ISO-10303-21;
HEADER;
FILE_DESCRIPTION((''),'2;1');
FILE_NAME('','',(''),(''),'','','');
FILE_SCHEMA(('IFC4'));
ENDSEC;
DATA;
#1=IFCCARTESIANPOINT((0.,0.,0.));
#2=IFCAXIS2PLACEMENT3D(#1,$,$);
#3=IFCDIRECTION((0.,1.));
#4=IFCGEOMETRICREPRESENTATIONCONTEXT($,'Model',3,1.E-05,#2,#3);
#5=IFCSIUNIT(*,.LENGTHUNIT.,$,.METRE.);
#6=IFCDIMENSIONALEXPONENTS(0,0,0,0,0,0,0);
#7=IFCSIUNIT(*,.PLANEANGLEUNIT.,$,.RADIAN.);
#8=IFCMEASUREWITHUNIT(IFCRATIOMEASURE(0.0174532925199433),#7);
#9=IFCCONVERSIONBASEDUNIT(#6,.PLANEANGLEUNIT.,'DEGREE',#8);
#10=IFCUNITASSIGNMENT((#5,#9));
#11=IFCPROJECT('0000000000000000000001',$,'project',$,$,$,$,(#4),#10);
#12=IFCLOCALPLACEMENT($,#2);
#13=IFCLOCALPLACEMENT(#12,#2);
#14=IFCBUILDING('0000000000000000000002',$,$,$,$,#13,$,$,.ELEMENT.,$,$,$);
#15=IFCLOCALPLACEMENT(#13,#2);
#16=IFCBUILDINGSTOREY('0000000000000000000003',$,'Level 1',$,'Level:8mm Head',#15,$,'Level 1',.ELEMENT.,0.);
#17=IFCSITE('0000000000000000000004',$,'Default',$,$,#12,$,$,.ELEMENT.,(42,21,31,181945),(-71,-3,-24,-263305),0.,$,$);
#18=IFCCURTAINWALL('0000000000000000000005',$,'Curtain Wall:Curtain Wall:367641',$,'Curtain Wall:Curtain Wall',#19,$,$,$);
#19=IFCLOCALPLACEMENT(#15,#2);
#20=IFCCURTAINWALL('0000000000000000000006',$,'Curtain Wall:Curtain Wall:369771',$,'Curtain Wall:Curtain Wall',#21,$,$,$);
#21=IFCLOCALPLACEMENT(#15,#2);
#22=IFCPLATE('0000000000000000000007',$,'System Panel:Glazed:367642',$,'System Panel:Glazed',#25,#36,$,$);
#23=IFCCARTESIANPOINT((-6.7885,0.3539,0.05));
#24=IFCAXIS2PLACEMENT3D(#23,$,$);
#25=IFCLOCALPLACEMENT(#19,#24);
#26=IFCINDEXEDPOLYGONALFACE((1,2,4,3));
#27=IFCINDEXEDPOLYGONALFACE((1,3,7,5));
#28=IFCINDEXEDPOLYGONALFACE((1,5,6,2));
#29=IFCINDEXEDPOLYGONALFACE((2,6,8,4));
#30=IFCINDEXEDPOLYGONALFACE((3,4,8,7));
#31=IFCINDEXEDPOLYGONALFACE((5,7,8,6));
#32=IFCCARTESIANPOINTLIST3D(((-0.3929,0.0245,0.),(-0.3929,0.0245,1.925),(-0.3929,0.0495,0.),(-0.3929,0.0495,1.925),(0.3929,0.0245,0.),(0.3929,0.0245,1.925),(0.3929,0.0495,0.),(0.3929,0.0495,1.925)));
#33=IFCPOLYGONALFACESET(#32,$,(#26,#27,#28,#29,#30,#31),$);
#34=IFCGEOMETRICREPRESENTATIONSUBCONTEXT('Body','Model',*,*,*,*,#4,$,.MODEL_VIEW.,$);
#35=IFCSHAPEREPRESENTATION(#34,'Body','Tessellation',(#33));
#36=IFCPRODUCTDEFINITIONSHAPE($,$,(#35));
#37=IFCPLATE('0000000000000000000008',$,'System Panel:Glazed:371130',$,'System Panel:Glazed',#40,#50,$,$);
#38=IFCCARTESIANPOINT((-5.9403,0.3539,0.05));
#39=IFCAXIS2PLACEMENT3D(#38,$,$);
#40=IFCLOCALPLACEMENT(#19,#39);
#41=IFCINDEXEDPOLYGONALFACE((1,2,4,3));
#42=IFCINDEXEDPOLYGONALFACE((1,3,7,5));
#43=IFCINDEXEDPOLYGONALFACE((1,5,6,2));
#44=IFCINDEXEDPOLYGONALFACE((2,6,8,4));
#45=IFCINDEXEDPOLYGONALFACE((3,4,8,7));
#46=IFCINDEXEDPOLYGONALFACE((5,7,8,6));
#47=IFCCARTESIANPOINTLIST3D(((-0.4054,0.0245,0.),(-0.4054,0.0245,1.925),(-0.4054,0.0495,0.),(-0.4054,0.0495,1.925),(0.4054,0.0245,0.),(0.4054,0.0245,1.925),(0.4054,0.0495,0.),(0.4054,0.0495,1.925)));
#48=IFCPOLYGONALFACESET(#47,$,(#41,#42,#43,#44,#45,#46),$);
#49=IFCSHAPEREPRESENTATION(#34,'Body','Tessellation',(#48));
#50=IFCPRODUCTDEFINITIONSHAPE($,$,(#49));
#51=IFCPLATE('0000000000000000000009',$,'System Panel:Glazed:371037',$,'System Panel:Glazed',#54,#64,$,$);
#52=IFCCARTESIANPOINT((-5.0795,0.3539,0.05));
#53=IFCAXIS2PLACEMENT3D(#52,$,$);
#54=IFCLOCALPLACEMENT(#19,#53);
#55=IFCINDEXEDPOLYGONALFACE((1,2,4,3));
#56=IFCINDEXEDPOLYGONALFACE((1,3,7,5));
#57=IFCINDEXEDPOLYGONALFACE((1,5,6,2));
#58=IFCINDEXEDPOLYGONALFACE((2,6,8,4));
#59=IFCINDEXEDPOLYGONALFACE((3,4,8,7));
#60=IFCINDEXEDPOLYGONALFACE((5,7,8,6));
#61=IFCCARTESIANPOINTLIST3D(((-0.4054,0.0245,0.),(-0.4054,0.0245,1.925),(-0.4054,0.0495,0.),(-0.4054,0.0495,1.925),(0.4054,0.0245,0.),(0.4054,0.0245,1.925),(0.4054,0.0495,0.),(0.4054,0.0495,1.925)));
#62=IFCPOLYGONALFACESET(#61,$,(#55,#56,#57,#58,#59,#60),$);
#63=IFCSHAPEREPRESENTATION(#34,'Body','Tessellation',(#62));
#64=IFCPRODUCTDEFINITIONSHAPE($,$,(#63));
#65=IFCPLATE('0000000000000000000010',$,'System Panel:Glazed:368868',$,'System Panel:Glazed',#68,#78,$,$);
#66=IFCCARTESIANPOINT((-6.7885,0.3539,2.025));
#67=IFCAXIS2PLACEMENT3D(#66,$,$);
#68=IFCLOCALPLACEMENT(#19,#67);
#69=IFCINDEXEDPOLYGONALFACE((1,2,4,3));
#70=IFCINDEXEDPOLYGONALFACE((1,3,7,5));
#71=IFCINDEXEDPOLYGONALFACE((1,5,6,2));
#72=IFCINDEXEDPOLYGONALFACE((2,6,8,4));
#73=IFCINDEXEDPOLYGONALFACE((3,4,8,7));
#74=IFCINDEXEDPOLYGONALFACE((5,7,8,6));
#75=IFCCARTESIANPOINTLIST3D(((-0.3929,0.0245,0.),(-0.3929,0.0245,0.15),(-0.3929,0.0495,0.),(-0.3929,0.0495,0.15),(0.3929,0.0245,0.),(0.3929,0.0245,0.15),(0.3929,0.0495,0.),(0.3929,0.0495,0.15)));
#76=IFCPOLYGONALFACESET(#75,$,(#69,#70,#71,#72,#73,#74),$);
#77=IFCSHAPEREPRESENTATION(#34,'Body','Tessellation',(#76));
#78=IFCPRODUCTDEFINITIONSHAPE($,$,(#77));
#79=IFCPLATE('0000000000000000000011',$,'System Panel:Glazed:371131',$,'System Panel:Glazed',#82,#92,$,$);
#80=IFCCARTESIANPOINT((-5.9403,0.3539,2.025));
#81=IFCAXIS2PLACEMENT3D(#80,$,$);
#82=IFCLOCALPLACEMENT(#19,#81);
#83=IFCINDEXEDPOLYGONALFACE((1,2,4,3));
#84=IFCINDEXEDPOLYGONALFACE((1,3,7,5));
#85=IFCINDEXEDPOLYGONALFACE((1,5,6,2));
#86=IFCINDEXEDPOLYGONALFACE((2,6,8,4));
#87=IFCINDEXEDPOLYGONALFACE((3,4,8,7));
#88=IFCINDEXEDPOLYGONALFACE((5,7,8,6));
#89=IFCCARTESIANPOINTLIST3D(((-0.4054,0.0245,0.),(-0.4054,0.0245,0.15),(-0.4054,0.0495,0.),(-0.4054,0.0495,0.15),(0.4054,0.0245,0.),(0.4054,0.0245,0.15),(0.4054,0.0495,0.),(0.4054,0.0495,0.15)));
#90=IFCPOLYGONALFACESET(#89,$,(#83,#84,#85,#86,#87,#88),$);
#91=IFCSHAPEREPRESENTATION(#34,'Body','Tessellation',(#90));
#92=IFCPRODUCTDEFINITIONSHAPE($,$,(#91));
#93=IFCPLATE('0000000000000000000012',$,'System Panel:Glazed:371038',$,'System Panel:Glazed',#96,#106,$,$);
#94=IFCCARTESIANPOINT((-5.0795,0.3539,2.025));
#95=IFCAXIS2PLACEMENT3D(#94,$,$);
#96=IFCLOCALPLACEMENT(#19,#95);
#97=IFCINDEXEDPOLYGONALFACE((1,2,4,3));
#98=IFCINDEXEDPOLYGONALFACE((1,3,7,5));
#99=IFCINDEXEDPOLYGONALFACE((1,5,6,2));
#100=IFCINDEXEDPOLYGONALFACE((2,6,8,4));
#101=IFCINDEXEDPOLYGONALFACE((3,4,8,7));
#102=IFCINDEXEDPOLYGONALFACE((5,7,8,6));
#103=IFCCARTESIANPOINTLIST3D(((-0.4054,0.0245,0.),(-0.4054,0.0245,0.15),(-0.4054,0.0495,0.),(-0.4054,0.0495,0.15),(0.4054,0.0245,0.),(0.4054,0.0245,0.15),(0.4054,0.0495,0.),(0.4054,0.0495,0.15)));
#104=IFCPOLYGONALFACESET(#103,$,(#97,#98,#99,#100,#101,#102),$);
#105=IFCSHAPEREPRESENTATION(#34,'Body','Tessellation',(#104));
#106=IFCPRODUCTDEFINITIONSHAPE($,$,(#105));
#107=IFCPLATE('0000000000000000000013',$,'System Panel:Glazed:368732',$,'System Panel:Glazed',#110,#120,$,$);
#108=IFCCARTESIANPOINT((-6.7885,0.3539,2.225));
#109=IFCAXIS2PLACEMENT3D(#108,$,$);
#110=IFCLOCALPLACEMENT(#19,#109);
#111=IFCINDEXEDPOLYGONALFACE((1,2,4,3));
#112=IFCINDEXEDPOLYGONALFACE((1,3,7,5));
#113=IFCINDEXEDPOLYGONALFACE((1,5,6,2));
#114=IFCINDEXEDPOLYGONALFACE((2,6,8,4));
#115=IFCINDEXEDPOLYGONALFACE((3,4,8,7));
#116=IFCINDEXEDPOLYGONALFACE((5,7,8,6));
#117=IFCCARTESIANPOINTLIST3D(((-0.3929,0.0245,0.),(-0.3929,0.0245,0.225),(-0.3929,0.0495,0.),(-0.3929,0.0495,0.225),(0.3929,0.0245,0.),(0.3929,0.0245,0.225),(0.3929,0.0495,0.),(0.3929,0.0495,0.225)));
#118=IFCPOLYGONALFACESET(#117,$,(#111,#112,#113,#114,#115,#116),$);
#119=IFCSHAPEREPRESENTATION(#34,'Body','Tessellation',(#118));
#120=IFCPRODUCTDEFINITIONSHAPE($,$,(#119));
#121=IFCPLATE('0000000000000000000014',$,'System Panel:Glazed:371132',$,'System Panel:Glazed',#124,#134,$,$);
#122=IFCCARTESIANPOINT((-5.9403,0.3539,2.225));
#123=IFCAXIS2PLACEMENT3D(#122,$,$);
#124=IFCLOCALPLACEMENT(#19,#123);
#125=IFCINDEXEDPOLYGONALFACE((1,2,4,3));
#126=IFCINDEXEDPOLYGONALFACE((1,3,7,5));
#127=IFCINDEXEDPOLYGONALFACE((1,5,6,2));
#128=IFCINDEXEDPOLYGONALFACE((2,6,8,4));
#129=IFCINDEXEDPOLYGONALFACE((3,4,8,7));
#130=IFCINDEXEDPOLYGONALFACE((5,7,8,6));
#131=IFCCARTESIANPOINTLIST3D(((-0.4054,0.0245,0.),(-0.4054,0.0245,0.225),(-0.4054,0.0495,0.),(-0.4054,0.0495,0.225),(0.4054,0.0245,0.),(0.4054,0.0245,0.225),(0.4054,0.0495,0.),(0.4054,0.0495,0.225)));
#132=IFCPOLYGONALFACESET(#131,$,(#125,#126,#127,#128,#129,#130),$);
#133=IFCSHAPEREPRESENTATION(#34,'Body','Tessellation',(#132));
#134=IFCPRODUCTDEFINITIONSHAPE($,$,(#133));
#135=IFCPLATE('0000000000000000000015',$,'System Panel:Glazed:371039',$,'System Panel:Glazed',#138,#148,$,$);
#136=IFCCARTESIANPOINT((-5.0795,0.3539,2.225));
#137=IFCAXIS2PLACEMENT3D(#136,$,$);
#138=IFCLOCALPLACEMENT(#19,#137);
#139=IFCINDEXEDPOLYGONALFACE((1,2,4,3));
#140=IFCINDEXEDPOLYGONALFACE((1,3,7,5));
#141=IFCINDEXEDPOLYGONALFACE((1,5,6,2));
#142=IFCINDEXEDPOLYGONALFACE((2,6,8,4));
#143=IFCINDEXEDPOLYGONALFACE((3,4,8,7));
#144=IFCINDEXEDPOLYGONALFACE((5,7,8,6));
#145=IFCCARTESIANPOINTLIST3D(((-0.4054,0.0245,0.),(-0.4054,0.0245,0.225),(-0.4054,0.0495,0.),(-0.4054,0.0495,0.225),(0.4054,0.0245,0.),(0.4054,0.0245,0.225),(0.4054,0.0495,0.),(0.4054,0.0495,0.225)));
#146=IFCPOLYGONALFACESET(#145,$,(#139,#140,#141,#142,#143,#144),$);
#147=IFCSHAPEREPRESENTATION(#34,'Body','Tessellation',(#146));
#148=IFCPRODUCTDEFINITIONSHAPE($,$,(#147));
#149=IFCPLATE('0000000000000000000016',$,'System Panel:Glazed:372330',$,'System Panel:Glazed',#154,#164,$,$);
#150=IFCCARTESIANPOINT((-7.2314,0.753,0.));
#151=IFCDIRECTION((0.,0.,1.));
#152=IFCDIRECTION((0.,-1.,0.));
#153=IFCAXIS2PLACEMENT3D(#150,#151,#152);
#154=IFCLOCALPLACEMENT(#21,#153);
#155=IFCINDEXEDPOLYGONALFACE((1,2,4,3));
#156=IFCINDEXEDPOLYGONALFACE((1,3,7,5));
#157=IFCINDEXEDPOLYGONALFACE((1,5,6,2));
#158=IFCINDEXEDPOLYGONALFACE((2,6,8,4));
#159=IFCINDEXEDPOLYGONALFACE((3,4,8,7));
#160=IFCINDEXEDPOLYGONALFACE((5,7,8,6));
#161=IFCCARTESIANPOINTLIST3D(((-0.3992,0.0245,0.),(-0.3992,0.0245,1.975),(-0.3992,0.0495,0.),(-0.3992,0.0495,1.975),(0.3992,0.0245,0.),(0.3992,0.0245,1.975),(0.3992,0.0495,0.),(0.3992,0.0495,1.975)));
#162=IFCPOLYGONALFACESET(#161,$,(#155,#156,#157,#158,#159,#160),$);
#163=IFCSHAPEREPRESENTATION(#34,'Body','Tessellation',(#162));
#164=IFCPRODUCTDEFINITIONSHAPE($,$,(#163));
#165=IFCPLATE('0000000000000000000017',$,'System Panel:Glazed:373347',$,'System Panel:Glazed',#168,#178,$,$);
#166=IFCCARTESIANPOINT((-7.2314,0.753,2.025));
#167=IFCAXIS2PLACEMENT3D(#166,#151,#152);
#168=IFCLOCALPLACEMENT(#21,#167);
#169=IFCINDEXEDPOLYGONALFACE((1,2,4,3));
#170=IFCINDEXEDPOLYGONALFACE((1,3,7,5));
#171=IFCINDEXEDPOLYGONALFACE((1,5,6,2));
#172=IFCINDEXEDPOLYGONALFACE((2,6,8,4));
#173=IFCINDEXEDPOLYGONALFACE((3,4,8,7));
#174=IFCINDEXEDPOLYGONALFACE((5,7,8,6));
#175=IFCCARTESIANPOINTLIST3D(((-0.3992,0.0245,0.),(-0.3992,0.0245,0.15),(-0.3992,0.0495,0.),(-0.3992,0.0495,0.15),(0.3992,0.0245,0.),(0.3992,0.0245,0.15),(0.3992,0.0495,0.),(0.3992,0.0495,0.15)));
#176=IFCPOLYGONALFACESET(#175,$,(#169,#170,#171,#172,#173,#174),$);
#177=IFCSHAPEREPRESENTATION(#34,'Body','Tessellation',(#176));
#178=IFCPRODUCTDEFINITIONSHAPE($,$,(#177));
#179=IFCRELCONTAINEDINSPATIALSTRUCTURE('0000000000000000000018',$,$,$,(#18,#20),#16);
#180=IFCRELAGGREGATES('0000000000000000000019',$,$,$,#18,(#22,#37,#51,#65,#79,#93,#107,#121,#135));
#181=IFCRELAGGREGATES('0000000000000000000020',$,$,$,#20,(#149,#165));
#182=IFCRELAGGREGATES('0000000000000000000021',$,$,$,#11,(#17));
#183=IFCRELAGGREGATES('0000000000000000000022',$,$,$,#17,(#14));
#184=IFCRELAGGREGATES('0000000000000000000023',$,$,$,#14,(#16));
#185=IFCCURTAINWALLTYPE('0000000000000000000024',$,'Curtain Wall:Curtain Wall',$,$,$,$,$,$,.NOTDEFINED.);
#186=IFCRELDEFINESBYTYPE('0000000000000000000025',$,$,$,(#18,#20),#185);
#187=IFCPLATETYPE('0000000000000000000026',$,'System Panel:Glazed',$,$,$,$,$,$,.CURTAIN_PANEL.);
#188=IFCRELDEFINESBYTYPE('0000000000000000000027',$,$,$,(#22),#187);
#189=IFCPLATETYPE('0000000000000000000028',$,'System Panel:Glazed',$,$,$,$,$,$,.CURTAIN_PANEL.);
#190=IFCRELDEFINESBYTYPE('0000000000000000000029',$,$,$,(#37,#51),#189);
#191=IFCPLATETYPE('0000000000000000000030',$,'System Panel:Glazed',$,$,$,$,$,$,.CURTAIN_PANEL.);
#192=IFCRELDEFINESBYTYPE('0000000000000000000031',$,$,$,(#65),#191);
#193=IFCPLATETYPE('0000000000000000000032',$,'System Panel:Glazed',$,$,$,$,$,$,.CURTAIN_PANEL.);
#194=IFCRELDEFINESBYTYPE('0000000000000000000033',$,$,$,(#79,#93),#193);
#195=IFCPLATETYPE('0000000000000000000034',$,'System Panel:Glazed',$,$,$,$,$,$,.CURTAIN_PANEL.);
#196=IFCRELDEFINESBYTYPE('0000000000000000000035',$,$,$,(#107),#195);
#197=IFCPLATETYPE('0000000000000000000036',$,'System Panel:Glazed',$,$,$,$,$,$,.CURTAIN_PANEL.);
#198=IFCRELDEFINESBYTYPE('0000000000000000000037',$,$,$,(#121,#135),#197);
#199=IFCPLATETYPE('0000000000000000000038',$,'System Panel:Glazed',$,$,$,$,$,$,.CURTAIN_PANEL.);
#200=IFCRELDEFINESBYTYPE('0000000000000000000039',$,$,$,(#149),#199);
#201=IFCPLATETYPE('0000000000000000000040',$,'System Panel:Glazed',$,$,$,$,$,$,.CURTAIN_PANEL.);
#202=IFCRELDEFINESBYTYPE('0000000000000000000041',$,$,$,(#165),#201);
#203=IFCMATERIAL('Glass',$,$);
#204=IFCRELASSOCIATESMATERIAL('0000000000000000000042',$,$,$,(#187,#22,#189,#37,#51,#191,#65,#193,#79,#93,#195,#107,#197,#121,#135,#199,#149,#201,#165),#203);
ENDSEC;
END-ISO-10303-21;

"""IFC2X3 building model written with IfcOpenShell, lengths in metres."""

from ifc_helpers import new_model, entity, si_unit, converted_unit, direction, frame, origin, origin_2d_with_axis, place, context, subcontext, project, spatial, rectangle, extrude, source, transform, mapped, material, type_object, type_shapes, element, aggregate, save


model = new_model("IFC2X3")

# Units and contexts
model_context = context("Model", 3, precision=1e-05, world=origin(), true_north=direction((0.0, 1.0)))
body_context = subcontext(model_context, "Body", "Model", "MODEL_VIEW")
ifc_project = project(units=[si_unit("LENGTHUNIT", "METRE"), converted_unit("PLANEANGLEUNIT", "DEGREE", entity("IfcRatioMeasure", 0.0174532925199433), si_unit("PLANEANGLEUNIT", "RADIAN"), dimensions=[0, 0, 0, 0, 0, 0, 0])], contexts=[model_context])

# Site, building, storey
site_placement = place(None, origin())
site = spatial("IfcSite", under=ifc_project, at=site_placement, Name="Default", CompositionType="ELEMENT", RefLatitude=(42, 21, 31, 181945), RefLongitude=(-71, -3, -24, -263305), RefElevation=0.0)
building_placement = place(site_placement, origin())
building = spatial("IfcBuilding", under=site, at=building_placement, CompositionType="ELEMENT")
storey_placement = place(building_placement, origin())
storey = spatial("IfcBuildingStorey", under=building, at=storey_placement, Name="Level 1", ObjectType="Level:8mm Head", LongName="Level 1", CompositionType="ELEMENT", Elevation=0.0)

# Curtain walls
curtain_wall_type = type_object("IfcCurtainWallType", Name="Curtain Wall:Curtain Wall", PredefinedType="NOTDEFINED")
curtain_wall_1_placement = place(storey_placement, origin())
curtain_wall_1 = element("IfcCurtainWall", 1, at=curtain_wall_1_placement, inside=storey, type_object=curtain_wall_type, Name="Curtain Wall:Curtain Wall:367641", ObjectType="Curtain Wall:Curtain Wall")
curtain_wall_2_placement = place(storey_placement, origin())
curtain_wall_2 = element("IfcCurtainWall", 2, at=curtain_wall_2_placement, inside=storey, type_object=curtain_wall_type, Name="Curtain Wall:Curtain Wall:369771", ObjectType="Curtain Wall:Curtain Wall")

# Plates
ifc_material_1 = material(Name="Glass")
plate_type_1 = type_object("IfcPlateType", Name="System Panel:Glazed", PredefinedType="CURTAIN_PANEL", material=ifc_material_1)
shared_shape_1 = source(origin(), body_context, "Body", "SweptSolid", [
    extrude(rectangle(XDim=0.025, YDim=0.7857, at=origin_2d_with_axis()), frame((0.0, 0.037, 0.0), z_axis=(0.0, 0.0, 1.0), x_axis=(0.0, 1.0, 0.0)), (0.0, 0.0, 1.0), 1.925),
])
type_shapes(plate_type_1, [shared_shape_1])
plate_1_placement = place(curtain_wall_1_placement, frame((-6.7885, 0.3539, 0.05)))
plate_1 = element("IfcPlate", 3, at=plate_1_placement, type_object=plate_type_1, material=ifc_material_1, Name="System Panel:Glazed:367642", ObjectType="System Panel:Glazed", context=body_context, shape_type="MappedRepresentation", body=[
    mapped(shared_shape_1, transform((0.0, 0.0, 0.0), scale=1.0)),
])
plate_type_2 = type_object("IfcPlateType", Name="System Panel:Glazed", PredefinedType="CURTAIN_PANEL", material=ifc_material_1)
shared_shape_2 = source(origin(), body_context, "Body", "SweptSolid", [
    extrude(rectangle(XDim=0.025, YDim=0.8107, at=origin_2d_with_axis()), frame((0.0, 0.037, 0.0), z_axis=(0.0, 0.0, 1.0), x_axis=(0.0, 1.0, 0.0)), (0.0, 0.0, 1.0), 1.925),
])
type_shapes(plate_type_2, [shared_shape_2])
plate_2_placement = place(curtain_wall_1_placement, frame((-5.9403, 0.3539, 0.05)))
plate_2 = element("IfcPlate", 4, at=plate_2_placement, type_object=plate_type_2, material=ifc_material_1, Name="System Panel:Glazed:371130", ObjectType="System Panel:Glazed", context=body_context, shape_type="MappedRepresentation", body=[
    mapped(shared_shape_2, transform((0.0, 0.0, 0.0), scale=1.0)),
])
plate_3_placement = place(curtain_wall_1_placement, frame((-5.0795, 0.3539, 0.05)))
plate_3 = element("IfcPlate", 5, at=plate_3_placement, type_object=plate_type_2, material=ifc_material_1, Name="System Panel:Glazed:371037", ObjectType="System Panel:Glazed", context=body_context, shape_type="MappedRepresentation", body=[
    mapped(shared_shape_2, transform((0.0, 0.0, 0.0), scale=1.0)),
])
plate_type_3 = type_object("IfcPlateType", Name="System Panel:Glazed", PredefinedType="CURTAIN_PANEL", material=ifc_material_1)
shared_shape_3 = source(origin(), body_context, "Body", "SweptSolid", [
    extrude(rectangle(XDim=0.025, YDim=0.7857, at=origin_2d_with_axis()), frame((0.0, 0.037, 0.0), z_axis=(0.0, 0.0, 1.0), x_axis=(0.0, 1.0, 0.0)), (0.0, 0.0, 1.0), 0.15),
])
type_shapes(plate_type_3, [shared_shape_3])
plate_4_placement = place(curtain_wall_1_placement, frame((-6.7885, 0.3539, 2.025)))
plate_4 = element("IfcPlate", 6, at=plate_4_placement, type_object=plate_type_3, material=ifc_material_1, Name="System Panel:Glazed:368868", ObjectType="System Panel:Glazed", context=body_context, shape_type="MappedRepresentation", body=[
    mapped(shared_shape_3, transform((0.0, 0.0, 0.0), scale=1.0)),
])
plate_type_4 = type_object("IfcPlateType", Name="System Panel:Glazed", PredefinedType="CURTAIN_PANEL", material=ifc_material_1)
shared_shape_4 = source(origin(), body_context, "Body", "SweptSolid", [
    extrude(rectangle(XDim=0.025, YDim=0.8107, at=origin_2d_with_axis()), frame((0.0, 0.037, 0.0), z_axis=(0.0, 0.0, 1.0), x_axis=(0.0, 1.0, 0.0)), (0.0, 0.0, 1.0), 0.15),
])
type_shapes(plate_type_4, [shared_shape_4])
plate_5_placement = place(curtain_wall_1_placement, frame((-5.9403, 0.3539, 2.025)))
plate_5 = element("IfcPlate", 7, at=plate_5_placement, type_object=plate_type_4, material=ifc_material_1, Name="System Panel:Glazed:371131", ObjectType="System Panel:Glazed", context=body_context, shape_type="MappedRepresentation", body=[
    mapped(shared_shape_4, transform((0.0, 0.0, 0.0), scale=1.0)),
])
plate_6_placement = place(curtain_wall_1_placement, frame((-5.0795, 0.3539, 2.025)))
plate_6 = element("IfcPlate", 8, at=plate_6_placement, type_object=plate_type_4, material=ifc_material_1, Name="System Panel:Glazed:371038", ObjectType="System Panel:Glazed", context=body_context, shape_type="MappedRepresentation", body=[
    mapped(shared_shape_4, transform((0.0, 0.0, 0.0), scale=1.0)),
])
plate_type_5 = type_object("IfcPlateType", Name="System Panel:Glazed", PredefinedType="CURTAIN_PANEL", material=ifc_material_1)
shared_shape_5 = source(origin(), body_context, "Body", "SweptSolid", [
    extrude(rectangle(XDim=0.025, YDim=0.7857, at=origin_2d_with_axis()), frame((0.0, 0.037, 0.0), z_axis=(0.0, 0.0, 1.0), x_axis=(0.0, 1.0, 0.0)), (0.0, 0.0, 1.0), 0.225),
])
type_shapes(plate_type_5, [shared_shape_5])
plate_7_placement = place(curtain_wall_1_placement, frame((-6.7885, 0.3539, 2.225)))
plate_7 = element("IfcPlate", 9, at=plate_7_placement, type_object=plate_type_5, material=ifc_material_1, Name="System Panel:Glazed:368732", ObjectType="System Panel:Glazed", context=body_context, shape_type="MappedRepresentation", body=[
    mapped(shared_shape_5, transform((0.0, 0.0, 0.0), scale=1.0)),
])
plate_type_6 = type_object("IfcPlateType", Name="System Panel:Glazed", PredefinedType="CURTAIN_PANEL", material=ifc_material_1)
shared_shape_6 = source(origin(), body_context, "Body", "SweptSolid", [
    extrude(rectangle(XDim=0.025, YDim=0.8107, at=origin_2d_with_axis()), frame((0.0, 0.037, 0.0), z_axis=(0.0, 0.0, 1.0), x_axis=(0.0, 1.0, 0.0)), (0.0, 0.0, 1.0), 0.225),
])
type_shapes(plate_type_6, [shared_shape_6])
plate_8_placement = place(curtain_wall_1_placement, frame((-5.9403, 0.3539, 2.225)))
plate_8 = element("IfcPlate", 10, at=plate_8_placement, type_object=plate_type_6, material=ifc_material_1, Name="System Panel:Glazed:371132", ObjectType="System Panel:Glazed", context=body_context, shape_type="MappedRepresentation", body=[
    mapped(shared_shape_6, transform((0.0, 0.0, 0.0), scale=1.0)),
])
plate_9_placement = place(curtain_wall_1_placement, frame((-5.0795, 0.3539, 2.225)))
plate_9 = element("IfcPlate", 11, at=plate_9_placement, type_object=plate_type_6, material=ifc_material_1, Name="System Panel:Glazed:371039", ObjectType="System Panel:Glazed", context=body_context, shape_type="MappedRepresentation", body=[
    mapped(shared_shape_6, transform((0.0, 0.0, 0.0), scale=1.0)),
])
aggregate(curtain_wall_1, [plate_1, plate_2, plate_3, plate_4, plate_5, plate_6, plate_7, plate_8, plate_9])
plate_type_7 = type_object("IfcPlateType", Name="System Panel:Glazed", PredefinedType="CURTAIN_PANEL", material=ifc_material_1)
shared_shape_7 = source(origin(), body_context, "Body", "SweptSolid", [
    extrude(rectangle(XDim=0.025, YDim=0.7983, at=origin_2d_with_axis()), frame((0.0, 0.037, 0.0), z_axis=(0.0, 0.0, 1.0), x_axis=(0.0, 1.0, 0.0)), (0.0, 0.0, 1.0), 1.975),
])
type_shapes(plate_type_7, [shared_shape_7])
plate_10_placement = place(curtain_wall_2_placement, frame((-7.2314, 0.753, 0.0), z_axis=(0.0, 0.0, 1.0), x_axis=(0.0, -1.0, 0.0)))
plate_10 = element("IfcPlate", 12, at=plate_10_placement, type_object=plate_type_7, material=ifc_material_1, Name="System Panel:Glazed:372330", ObjectType="System Panel:Glazed", context=body_context, shape_type="MappedRepresentation", body=[
    mapped(shared_shape_7, transform((0.0, 0.0, 0.0), scale=1.0)),
])
plate_type_8 = type_object("IfcPlateType", Name="System Panel:Glazed", PredefinedType="CURTAIN_PANEL", material=ifc_material_1)
shared_shape_8 = source(origin(), body_context, "Body", "SweptSolid", [
    extrude(rectangle(XDim=0.025, YDim=0.7983, at=origin_2d_with_axis()), frame((0.0, 0.037, 0.0), z_axis=(0.0, 0.0, 1.0), x_axis=(0.0, 1.0, 0.0)), (0.0, 0.0, 1.0), 0.15),
])
type_shapes(plate_type_8, [shared_shape_8])
plate_11_placement = place(curtain_wall_2_placement, frame((-7.2314, 0.753, 2.025), z_axis=(0.0, 0.0, 1.0), x_axis=(0.0, -1.0, 0.0)))
plate_11 = element("IfcPlate", 13, at=plate_11_placement, type_object=plate_type_8, material=ifc_material_1, Name="System Panel:Glazed:373347", ObjectType="System Panel:Glazed", context=body_context, shape_type="MappedRepresentation", body=[
    mapped(shared_shape_8, transform((0.0, 0.0, 0.0), scale=1.0)),
])
aggregate(curtain_wall_2, [plate_10, plate_11])

save(model, "model.ifc")
